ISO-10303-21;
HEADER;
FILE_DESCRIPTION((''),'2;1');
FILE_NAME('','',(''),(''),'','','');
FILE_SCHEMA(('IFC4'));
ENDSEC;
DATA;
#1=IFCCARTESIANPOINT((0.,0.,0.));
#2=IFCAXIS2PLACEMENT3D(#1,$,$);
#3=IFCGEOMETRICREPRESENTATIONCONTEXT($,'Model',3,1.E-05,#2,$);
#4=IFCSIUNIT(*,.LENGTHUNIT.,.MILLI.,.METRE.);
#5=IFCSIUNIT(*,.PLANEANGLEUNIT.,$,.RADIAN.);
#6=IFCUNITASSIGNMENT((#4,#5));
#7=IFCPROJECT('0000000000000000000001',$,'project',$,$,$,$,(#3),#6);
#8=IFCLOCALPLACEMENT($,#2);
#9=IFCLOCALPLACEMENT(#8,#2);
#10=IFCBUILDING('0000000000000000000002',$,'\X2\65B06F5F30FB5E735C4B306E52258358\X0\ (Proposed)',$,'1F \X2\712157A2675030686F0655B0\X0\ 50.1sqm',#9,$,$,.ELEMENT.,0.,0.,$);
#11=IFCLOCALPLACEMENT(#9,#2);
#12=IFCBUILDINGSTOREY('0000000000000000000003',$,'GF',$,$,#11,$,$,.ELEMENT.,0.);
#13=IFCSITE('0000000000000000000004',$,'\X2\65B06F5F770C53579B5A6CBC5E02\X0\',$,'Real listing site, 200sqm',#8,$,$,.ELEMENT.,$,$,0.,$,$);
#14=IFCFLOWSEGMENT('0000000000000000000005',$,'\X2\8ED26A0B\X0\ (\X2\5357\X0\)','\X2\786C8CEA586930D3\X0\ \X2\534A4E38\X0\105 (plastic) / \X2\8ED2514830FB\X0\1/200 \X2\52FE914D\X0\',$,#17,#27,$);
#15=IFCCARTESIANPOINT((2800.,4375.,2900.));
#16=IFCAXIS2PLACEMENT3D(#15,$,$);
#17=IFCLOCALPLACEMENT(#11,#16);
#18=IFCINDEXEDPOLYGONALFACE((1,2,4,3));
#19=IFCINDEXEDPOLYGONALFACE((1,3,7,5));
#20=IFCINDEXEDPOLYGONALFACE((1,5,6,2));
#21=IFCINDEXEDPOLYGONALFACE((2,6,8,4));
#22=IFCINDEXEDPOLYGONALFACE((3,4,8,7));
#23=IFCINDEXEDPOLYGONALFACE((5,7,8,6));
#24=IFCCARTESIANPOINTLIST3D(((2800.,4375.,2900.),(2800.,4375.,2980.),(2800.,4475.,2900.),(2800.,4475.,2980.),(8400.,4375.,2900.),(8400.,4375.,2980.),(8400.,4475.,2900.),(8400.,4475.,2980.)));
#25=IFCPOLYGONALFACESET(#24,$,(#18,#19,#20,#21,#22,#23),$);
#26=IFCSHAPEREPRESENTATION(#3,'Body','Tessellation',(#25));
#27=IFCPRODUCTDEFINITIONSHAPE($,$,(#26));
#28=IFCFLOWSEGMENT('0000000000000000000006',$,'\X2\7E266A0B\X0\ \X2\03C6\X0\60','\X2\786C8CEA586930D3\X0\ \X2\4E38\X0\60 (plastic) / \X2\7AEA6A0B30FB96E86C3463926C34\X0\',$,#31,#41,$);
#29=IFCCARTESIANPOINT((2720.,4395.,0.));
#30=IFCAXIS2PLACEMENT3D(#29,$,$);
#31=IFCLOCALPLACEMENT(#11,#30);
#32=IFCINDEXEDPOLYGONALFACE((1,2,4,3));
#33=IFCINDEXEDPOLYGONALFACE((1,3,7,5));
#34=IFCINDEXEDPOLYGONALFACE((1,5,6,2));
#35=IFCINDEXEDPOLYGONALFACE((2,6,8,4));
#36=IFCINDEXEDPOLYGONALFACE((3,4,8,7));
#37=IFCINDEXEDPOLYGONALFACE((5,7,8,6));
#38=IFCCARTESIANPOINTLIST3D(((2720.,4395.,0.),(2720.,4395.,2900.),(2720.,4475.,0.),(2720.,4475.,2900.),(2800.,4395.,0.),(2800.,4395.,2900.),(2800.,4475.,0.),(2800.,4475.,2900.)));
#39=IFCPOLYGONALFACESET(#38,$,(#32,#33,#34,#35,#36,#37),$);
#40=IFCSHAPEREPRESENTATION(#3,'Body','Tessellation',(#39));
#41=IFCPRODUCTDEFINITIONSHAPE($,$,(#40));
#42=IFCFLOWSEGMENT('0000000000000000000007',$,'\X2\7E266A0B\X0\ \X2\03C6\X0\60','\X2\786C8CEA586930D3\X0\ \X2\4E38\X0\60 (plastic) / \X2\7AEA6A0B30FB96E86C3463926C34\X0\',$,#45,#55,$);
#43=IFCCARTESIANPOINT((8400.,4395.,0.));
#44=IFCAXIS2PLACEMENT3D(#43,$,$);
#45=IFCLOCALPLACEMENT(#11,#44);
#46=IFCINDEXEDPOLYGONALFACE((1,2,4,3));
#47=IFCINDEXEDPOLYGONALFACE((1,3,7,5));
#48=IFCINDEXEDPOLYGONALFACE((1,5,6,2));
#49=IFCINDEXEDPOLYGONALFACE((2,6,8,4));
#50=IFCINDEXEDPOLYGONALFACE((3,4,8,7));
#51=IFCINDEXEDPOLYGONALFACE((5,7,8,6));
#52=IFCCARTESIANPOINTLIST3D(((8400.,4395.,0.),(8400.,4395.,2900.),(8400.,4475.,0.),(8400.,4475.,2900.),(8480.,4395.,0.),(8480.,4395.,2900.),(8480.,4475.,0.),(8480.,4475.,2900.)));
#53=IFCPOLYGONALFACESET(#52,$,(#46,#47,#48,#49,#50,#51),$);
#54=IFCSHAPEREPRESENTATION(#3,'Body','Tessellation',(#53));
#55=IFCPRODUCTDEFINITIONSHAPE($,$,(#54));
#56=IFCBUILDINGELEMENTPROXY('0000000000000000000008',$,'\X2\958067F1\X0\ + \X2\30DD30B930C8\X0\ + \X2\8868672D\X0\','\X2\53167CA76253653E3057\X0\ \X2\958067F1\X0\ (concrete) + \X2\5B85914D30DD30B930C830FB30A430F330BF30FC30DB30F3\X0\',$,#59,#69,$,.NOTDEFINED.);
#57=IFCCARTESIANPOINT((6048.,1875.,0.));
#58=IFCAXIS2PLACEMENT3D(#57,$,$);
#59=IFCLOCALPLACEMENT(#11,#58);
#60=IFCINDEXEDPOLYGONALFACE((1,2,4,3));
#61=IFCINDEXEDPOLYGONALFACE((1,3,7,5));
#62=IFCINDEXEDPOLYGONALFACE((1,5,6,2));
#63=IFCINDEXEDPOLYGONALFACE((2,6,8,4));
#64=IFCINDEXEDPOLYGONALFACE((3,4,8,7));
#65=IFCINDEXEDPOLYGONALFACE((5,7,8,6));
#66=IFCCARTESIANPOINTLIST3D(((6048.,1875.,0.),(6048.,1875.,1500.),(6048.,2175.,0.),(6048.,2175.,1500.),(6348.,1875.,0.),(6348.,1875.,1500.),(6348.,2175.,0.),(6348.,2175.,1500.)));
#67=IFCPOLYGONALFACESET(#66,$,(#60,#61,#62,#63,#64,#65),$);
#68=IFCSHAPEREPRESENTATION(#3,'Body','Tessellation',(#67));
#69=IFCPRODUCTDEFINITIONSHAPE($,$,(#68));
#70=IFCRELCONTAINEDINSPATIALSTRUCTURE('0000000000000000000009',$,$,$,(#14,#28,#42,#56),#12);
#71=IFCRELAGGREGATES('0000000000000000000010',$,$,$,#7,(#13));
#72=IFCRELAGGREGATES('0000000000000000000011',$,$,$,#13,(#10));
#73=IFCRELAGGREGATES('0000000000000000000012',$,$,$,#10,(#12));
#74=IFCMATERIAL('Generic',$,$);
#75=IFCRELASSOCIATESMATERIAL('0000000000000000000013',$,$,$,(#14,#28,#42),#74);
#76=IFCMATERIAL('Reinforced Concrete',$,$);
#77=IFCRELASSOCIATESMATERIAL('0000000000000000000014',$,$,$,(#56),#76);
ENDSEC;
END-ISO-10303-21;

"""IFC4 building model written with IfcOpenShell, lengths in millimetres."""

from ifc_helpers import new_model, si_unit, frame, frame_2d, origin, place, context, project, spatial, rectangle, extrude, material, element, save


model = new_model("IFC4")

# Units and contexts
model_context = context("Model", 3, precision=1e-05, world=origin())
ifc_project = project(units=[si_unit("LENGTHUNIT", "METRE", prefix="MILLI"), si_unit("PLANEANGLEUNIT", "RADIAN")], contexts=[model_context])

# Site, building, storey
site_placement = place(None, origin())
site = spatial("IfcSite", under=ifc_project, at=site_placement, Name="新潟県南魚沼市", ObjectType="Real listing site, 200sqm", CompositionType="ELEMENT", RefElevation=0.0)
building_placement = place(site_placement, origin())
building = spatial("IfcBuilding", under=site, at=building_placement, Name="新潟・平屋の別荘 (Proposed)", ObjectType="1F 無垢材と漆喰 50.1sqm", CompositionType="ELEMENT", ElevationOfRefHeight=0.0, ElevationOfTerrain=0.0)
storey_placement = place(building_placement, origin())
storey = spatial("IfcBuildingStorey", under=building, at=storey_placement, Name="GF", CompositionType="ELEMENT", Elevation=0.0)

# Shared definitions
ifc_material_1 = material(Name="Reinforced Concrete")

# Flow segments
ifc_material_2 = material(Name="Generic")
flow_segment_1_placement = place(storey_placement, frame((2800.0, 4375.0, 2900.0)))
element("IfcFlowSegment", 1, at=flow_segment_1_placement, inside=storey, material=ifc_material_2, Name="軒樋 (南)", Description="硬質塩ビ 半丸105 (plastic) / 軒先・1/200 勾配", context=model_context, shape_type="SweptSolid", body=[
    extrude(rectangle(XDim=5600.0, YDim=100.0, at=frame_2d((2800.0, 50.0))), frame((2800.0, 4375.0, 2900.0)), (0.0, 0.0, 1.0), 80.0),
])
flow_segment_2_placement = place(storey_placement, frame((2720.0, 4395.0, 0.0)))
element("IfcFlowSegment", 2, at=flow_segment_2_placement, inside=storey, material=ifc_material_2, Name="縦樋 φ60", Description="硬質塩ビ 丸60 (plastic) / 竪樋・雨水排水", context=model_context, shape_type="SweptSolid", body=[
    extrude(rectangle(XDim=80.0, YDim=80.0, at=frame_2d((40.0, 40.0))), frame((2720.0, 4395.0, 0.0)), (0.0, 0.0, 1.0), 2900.0),
])
flow_segment_3_placement = place(storey_placement, frame((8400.0, 4395.0, 0.0)))
element("IfcFlowSegment", 3, at=flow_segment_3_placement, inside=storey, material=ifc_material_2, Name="縦樋 φ60", Description="硬質塩ビ 丸60 (plastic) / 竪樋・雨水排水", context=model_context, shape_type="SweptSolid", body=[
    extrude(rectangle(XDim=80.0, YDim=80.0, at=frame_2d((40.0, 40.0))), frame((8400.0, 4395.0, 0.0)), (0.0, 0.0, 1.0), 2900.0),
])

# Building element proxy
proxy_placement = place(storey_placement, frame((6048.0, 1875.0, 0.0)))
element("IfcBuildingElementProxy", 4, at=proxy_placement, inside=storey, material=ifc_material_1, Name="門柱 + ポスト + 表札", Description="化粧打放し 門柱 (concrete) + 宅配ポスト・インターホン", PredefinedType="NOTDEFINED", context=model_context, shape_type="SweptSolid", body=[
    extrude(rectangle(XDim=300.0, YDim=300.0, at=frame_2d((150.0, 150.0))), frame((6048.0, 1875.0, 0.0)), (0.0, 0.0, 1.0), 1500.0),
])

save(model, "model.ifc")
